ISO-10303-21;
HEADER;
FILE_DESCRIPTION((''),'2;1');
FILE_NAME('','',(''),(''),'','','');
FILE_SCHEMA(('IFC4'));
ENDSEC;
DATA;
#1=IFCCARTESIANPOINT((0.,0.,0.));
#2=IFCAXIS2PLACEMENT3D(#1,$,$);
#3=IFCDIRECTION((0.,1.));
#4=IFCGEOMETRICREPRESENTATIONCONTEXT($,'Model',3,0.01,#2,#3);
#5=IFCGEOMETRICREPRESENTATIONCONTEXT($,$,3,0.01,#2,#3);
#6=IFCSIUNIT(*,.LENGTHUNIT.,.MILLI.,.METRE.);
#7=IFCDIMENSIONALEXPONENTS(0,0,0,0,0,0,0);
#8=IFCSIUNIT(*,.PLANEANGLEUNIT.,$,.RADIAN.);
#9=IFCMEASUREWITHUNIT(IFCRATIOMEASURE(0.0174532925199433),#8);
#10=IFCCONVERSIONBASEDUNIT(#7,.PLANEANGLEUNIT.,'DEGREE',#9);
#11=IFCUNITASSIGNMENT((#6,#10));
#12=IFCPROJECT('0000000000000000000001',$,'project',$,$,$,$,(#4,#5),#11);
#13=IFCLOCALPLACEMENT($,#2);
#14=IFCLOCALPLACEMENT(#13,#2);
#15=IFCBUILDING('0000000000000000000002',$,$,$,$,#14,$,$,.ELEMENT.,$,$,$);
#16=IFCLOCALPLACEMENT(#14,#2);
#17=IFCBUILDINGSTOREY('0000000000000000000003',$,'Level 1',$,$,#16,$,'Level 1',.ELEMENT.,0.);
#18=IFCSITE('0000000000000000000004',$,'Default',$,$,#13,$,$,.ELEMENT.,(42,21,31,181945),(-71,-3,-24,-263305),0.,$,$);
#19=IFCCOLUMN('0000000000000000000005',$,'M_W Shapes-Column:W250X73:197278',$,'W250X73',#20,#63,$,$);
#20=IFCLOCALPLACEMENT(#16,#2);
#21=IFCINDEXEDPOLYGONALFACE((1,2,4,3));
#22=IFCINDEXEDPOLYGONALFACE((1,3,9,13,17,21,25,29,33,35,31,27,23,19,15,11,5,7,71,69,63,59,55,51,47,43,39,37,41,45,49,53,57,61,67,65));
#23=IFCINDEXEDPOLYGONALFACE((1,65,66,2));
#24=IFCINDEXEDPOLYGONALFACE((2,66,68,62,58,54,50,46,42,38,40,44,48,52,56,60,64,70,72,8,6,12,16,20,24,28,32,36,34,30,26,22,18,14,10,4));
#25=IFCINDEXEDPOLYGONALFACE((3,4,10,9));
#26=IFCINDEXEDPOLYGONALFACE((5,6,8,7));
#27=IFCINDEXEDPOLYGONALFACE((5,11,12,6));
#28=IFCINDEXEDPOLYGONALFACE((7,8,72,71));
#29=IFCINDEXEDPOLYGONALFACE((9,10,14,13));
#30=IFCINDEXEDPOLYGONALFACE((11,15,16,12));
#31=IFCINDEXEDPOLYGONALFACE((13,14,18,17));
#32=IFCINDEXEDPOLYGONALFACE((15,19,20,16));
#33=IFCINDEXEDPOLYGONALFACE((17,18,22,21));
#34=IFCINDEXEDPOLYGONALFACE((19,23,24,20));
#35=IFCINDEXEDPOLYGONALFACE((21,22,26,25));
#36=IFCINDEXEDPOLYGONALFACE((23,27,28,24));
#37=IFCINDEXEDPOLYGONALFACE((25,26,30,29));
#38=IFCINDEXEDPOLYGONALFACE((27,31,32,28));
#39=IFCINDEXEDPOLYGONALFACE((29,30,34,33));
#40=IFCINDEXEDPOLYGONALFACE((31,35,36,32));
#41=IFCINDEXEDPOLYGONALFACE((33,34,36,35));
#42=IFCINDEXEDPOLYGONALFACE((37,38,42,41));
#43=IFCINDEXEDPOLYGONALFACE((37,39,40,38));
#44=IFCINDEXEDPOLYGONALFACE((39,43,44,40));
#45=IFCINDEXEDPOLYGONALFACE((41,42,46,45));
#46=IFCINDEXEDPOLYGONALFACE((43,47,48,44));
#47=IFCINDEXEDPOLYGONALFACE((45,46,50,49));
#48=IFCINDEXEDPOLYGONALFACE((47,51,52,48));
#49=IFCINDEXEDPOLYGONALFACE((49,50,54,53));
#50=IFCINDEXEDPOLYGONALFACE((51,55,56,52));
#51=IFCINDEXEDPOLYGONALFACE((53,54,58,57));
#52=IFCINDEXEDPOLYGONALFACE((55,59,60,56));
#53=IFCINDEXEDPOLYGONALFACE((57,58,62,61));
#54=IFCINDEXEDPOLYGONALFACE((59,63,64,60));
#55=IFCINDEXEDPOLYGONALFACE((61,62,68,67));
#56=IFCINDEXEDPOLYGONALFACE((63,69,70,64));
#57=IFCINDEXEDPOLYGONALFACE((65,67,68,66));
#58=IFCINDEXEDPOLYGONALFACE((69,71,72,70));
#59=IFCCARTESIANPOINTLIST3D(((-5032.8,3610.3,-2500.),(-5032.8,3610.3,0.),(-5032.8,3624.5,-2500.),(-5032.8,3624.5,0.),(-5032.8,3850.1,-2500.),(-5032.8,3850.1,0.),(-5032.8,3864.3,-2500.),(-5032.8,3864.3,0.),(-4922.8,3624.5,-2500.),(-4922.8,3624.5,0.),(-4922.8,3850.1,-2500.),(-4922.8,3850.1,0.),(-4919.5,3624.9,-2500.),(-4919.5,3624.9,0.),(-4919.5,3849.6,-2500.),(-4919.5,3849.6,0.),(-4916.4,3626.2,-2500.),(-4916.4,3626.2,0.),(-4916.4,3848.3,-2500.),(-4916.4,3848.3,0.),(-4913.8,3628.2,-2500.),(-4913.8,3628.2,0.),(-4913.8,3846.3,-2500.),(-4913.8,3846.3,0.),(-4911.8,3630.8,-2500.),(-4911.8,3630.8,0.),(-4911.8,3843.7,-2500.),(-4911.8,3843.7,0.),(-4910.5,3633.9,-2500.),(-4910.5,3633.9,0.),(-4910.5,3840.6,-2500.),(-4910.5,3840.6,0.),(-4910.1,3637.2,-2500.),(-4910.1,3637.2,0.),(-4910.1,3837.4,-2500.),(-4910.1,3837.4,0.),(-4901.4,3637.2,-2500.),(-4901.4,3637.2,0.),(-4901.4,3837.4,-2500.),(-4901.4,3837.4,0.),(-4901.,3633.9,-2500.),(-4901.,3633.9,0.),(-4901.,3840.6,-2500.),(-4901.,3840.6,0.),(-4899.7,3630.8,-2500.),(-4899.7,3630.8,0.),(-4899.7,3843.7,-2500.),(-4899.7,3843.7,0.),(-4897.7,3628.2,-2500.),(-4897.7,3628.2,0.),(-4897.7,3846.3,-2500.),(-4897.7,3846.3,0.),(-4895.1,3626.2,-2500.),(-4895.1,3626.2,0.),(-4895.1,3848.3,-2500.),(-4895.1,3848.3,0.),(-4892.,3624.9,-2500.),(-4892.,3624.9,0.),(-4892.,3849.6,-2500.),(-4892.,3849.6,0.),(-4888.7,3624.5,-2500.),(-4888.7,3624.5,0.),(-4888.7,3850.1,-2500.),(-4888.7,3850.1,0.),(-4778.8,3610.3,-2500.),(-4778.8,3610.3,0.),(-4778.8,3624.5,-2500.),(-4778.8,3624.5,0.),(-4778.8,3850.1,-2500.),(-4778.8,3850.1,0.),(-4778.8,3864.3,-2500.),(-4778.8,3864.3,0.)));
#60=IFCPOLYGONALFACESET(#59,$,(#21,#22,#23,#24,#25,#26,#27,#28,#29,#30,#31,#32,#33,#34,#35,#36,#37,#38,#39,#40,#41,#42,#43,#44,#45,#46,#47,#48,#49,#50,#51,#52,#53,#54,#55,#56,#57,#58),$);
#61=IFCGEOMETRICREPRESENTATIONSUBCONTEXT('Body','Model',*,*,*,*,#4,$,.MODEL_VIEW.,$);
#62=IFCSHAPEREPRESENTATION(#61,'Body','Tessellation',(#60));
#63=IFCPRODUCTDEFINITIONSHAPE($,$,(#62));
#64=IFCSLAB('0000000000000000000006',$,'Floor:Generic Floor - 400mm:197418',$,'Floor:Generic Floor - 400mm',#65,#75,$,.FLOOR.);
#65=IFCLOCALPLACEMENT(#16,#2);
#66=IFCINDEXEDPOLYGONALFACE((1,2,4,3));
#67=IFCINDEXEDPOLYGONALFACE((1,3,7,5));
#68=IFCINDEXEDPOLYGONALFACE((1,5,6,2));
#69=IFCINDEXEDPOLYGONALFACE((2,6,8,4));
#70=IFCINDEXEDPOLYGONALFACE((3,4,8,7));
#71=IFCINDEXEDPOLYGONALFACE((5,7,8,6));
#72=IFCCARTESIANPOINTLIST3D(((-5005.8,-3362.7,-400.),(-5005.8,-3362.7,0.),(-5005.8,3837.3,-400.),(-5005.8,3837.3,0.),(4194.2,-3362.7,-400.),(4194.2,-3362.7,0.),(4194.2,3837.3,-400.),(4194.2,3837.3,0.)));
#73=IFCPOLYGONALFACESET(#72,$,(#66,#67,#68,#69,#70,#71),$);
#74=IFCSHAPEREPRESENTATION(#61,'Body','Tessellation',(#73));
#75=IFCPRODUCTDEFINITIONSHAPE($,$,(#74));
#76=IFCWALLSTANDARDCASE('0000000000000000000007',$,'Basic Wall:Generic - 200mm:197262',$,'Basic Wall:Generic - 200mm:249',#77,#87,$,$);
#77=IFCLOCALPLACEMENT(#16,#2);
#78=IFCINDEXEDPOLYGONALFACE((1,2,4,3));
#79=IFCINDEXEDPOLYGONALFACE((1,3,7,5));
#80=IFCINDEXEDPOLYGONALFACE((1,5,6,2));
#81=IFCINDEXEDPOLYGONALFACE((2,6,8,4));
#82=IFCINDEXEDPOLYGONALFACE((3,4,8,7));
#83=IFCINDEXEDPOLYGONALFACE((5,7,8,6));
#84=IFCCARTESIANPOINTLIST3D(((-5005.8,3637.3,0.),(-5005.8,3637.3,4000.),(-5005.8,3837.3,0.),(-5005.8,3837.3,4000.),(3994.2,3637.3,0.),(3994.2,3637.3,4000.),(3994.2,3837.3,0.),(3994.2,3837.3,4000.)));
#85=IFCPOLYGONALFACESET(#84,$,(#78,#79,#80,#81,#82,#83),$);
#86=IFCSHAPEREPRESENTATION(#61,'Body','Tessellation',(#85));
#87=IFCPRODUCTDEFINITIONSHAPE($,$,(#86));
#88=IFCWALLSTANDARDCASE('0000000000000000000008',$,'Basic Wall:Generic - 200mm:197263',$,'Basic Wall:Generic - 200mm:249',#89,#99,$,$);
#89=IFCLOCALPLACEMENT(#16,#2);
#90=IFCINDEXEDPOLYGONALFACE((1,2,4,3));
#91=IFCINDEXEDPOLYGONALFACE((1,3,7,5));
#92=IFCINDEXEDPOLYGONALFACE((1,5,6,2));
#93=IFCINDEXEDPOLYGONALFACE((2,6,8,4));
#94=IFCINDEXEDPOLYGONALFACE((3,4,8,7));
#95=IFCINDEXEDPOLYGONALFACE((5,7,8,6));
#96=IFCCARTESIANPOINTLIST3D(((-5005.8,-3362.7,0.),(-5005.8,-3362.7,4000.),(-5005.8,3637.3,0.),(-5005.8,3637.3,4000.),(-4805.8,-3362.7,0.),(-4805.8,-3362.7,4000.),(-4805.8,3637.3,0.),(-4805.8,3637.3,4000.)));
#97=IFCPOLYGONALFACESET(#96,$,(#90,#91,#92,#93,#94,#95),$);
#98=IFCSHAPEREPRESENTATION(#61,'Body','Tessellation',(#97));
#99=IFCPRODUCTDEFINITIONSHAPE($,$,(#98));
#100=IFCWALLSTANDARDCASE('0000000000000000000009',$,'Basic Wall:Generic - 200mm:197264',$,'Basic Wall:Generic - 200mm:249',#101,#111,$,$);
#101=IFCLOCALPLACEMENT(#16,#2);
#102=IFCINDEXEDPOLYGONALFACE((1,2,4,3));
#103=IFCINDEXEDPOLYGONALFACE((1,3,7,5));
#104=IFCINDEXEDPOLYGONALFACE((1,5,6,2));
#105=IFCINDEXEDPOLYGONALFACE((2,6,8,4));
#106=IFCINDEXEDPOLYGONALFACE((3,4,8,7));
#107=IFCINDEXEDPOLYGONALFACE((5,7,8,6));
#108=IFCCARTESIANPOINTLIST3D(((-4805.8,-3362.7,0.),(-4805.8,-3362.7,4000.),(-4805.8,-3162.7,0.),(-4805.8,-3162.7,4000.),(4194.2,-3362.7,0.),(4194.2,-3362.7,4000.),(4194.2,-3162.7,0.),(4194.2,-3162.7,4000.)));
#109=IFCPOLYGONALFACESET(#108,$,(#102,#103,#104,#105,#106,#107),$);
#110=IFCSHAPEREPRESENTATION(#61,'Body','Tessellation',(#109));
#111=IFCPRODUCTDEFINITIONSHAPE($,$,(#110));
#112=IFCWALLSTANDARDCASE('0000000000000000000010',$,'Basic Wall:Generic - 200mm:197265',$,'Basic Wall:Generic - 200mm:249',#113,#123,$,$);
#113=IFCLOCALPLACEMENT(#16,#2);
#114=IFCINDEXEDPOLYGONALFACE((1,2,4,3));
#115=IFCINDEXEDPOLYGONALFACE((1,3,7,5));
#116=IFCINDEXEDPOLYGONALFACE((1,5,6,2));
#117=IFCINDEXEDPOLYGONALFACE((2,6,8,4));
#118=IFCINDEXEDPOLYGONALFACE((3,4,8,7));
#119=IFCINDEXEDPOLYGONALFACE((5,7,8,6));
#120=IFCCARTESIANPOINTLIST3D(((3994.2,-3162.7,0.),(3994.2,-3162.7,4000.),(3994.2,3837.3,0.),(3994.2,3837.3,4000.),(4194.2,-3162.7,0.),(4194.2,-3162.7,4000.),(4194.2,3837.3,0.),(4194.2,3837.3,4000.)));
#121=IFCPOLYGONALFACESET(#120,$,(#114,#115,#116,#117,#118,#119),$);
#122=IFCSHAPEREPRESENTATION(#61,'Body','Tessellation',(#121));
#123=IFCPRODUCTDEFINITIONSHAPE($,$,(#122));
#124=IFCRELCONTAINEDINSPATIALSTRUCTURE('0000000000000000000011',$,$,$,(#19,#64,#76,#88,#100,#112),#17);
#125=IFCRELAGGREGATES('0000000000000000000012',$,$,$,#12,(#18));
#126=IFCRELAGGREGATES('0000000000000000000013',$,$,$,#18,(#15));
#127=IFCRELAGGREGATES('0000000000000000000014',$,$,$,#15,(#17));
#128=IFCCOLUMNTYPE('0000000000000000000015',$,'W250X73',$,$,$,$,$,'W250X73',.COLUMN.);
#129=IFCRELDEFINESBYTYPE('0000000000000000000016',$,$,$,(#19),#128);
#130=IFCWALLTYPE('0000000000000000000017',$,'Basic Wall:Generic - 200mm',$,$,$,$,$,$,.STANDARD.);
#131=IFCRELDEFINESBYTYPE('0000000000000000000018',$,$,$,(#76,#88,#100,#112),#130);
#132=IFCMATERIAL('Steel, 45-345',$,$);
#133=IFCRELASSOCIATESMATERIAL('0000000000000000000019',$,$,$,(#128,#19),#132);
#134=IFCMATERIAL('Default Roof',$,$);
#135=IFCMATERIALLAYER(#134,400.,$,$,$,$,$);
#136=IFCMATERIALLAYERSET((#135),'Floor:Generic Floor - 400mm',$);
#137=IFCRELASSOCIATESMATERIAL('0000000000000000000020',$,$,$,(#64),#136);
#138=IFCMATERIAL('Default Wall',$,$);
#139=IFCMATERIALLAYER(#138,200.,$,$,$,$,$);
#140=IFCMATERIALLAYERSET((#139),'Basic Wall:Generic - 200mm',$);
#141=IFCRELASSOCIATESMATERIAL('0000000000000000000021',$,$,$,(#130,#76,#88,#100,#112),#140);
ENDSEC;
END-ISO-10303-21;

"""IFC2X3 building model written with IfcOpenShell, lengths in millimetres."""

from ifc_helpers import new_model, entity, si_unit, converted_unit, direction, frame, frame_2d, origin, origin_2d_with_axis, place, context, subcontext, project, spatial, rectangle, i_section, extrude, source, transform, mapped, material, layer, layer_set, layer_usage, type_object, type_shapes, element, save


model = new_model("IFC2X3")

# Units and contexts
model_context = context("Model", 3, precision=0.01, world=origin(), true_north=direction((0.0, 1.0)))
context_of_model = context(None, 3, precision=0.01, world=origin(), true_north=direction((0.0, 1.0)))
body_context = subcontext(model_context, "Body", "Model", "MODEL_VIEW")
ifc_project = project(units=[si_unit("LENGTHUNIT", "METRE", prefix="MILLI"), converted_unit("PLANEANGLEUNIT", "DEGREE", entity("IfcRatioMeasure", 0.0174532925199433), si_unit("PLANEANGLEUNIT", "RADIAN"), dimensions=[0, 0, 0, 0, 0, 0, 0])], contexts=[model_context, context_of_model])

# Site, building, storey
site_placement = place(None, origin())
site = spatial("IfcSite", under=ifc_project, at=site_placement, Name="Default", CompositionType="ELEMENT", RefLatitude=(42, 21, 31, 181945), RefLongitude=(-71, -3, -24, -263305), RefElevation=0.0)
building_placement = place(site_placement, origin())
building = spatial("IfcBuilding", under=site, at=building_placement, CompositionType="ELEMENT")
storey_placement = place(building_placement, origin())
storey = spatial("IfcBuildingStorey", under=building, at=storey_placement, Name="Level 1", LongName="Level 1", CompositionType="ELEMENT", Elevation=0.0)

# Column
ifc_material_1 = material(Name="Steel, 45-345")
column_type = type_object("IfcColumnType", Name="W250X73", ElementType="W250X73", PredefinedType="COLUMN", material=ifc_material_1)
shared_shape = source(origin(), body_context, "Body", "SweptSolid", [
    extrude(i_section(OverallWidth=254.0, OverallDepth=254.0, WebThickness=8.6, FlangeThickness=14.2, FilletRadius=12.7, at=frame_2d((0.0, 0.0), x_axis=(1.0, 0.0))), frame((0.0, 0.0, -2500.0), z_axis=(0.0, 0.0, 1.0), x_axis=(-1.0, 0.0, 0.0)), (0.0, 0.0, 1.0), 2500.0),
])
type_shapes(column_type, [shared_shape])
column_placement = place(storey_placement, frame((-4905.8, 3737.3, 0.0)))
element("IfcColumn", 1, at=column_placement, inside=storey, type_object=column_type, material=ifc_material_1, Name="M_W Shapes-Column:W250X73:197278", ObjectType="W250X73", context=body_context, shape_type="MappedRepresentation", body=[
    mapped(shared_shape, transform((0.0, 0.0, 0.0), scale=1.0)),
])

# Slab
ifc_material_2 = material(Name="Default Roof")
ifc_layer_1 = layer(ifc_material_2, 400.0)
ifc_layer_set_1 = layer_set([ifc_layer_1], Name="Floor:Generic Floor - 400mm")
ifc_layer_usage_1 = layer_usage(ifc_layer_set_1, "AXIS3", "POSITIVE", 0.0)
slab_placement = place(storey_placement, origin())
element("IfcSlab", 2, at=slab_placement, inside=storey, material=ifc_layer_usage_1, Name="Floor:Generic Floor - 400mm:197418", ObjectType="Floor:Generic Floor - 400mm", PredefinedType="FLOOR", context=body_context, shape_type="SweptSolid", body=[
    extrude(rectangle(XDim=7200.0, YDim=9200.0, at=origin_2d_with_axis()), frame((-405.8, 237.3, 0.0), z_axis=(0.0, 0.0, -1.0), x_axis=(0.0, 1.0, 0.0)), (0.0, 0.0, 1.0), 400.0),
])

# Walls
ifc_material_3 = material(Name="Default Wall")
ifc_layer_2 = layer(ifc_material_3, 200.0)
ifc_layer_set_2 = layer_set([ifc_layer_2], Name="Basic Wall:Generic - 200mm")
ifc_layer_usage_2 = layer_usage(ifc_layer_set_2, "AXIS2", "NEGATIVE", 100.0)
wall_type = type_object("IfcWallType", Name="Basic Wall:Generic - 200mm", PredefinedType="STANDARD", material=ifc_layer_set_2)
wall_1_placement = place(storey_placement, frame((-5005.8, 3737.3, 0.0)))
element("IfcWallStandardCase", 3, at=wall_1_placement, inside=storey, type_object=wall_type, material=ifc_layer_usage_2, Name="Basic Wall:Generic - 200mm:197262", ObjectType="Basic Wall:Generic - 200mm:249", context=body_context, shape_type="SweptSolid", body=[
    extrude(rectangle(XDim=9000.0, YDim=200.0, at=frame_2d((4500.0, 0.0), x_axis=(-1.0, 0.0))), origin(), (0.0, 0.0, 1.0), 4000.0),
])
ifc_layer_usage_3 = layer_usage(ifc_layer_set_2, "AXIS2", "NEGATIVE", 100.0)
wall_2_placement = place(storey_placement, frame((-4905.8, -3362.7, 0.0), z_axis=(0.0, 0.0, 1.0), x_axis=(0.0, 1.0, 0.0)))
element("IfcWallStandardCase", 4, at=wall_2_placement, inside=storey, type_object=wall_type, material=ifc_layer_usage_3, Name="Basic Wall:Generic - 200mm:197263", ObjectType="Basic Wall:Generic - 200mm:249", context=body_context, shape_type="SweptSolid", body=[
    extrude(rectangle(XDim=7000.0, YDim=200.0, at=frame_2d((3500.0, 0.0), x_axis=(-1.0, 0.0))), origin(), (0.0, 0.0, 1.0), 4000.0),
])
ifc_layer_usage_4 = layer_usage(ifc_layer_set_2, "AXIS2", "NEGATIVE", 100.0)
wall_3_placement = place(storey_placement, frame((4194.2, -3262.7, 0.0), z_axis=(0.0, 0.0, 1.0), x_axis=(-1.0, 0.0, 0.0)))
element("IfcWallStandardCase", 5, at=wall_3_placement, inside=storey, type_object=wall_type, material=ifc_layer_usage_4, Name="Basic Wall:Generic - 200mm:197264", ObjectType="Basic Wall:Generic - 200mm:249", context=body_context, shape_type="SweptSolid", body=[
    extrude(rectangle(XDim=9000.0, YDim=200.0, at=frame_2d((4500.0, 0.0), x_axis=(-1.0, 0.0))), origin(), (0.0, 0.0, 1.0), 4000.0),
])
ifc_layer_usage_5 = layer_usage(ifc_layer_set_2, "AXIS2", "NEGATIVE", 100.0)
wall_4_placement = place(storey_placement, frame((4094.2, 3837.3, 0.0), z_axis=(0.0, 0.0, 1.0), x_axis=(0.0, -1.0, 0.0)))
element("IfcWallStandardCase", 6, at=wall_4_placement, inside=storey, type_object=wall_type, material=ifc_layer_usage_5, Name="Basic Wall:Generic - 200mm:197265", ObjectType="Basic Wall:Generic - 200mm:249", context=body_context, shape_type="SweptSolid", body=[
    extrude(rectangle(XDim=7000.0, YDim=200.0, at=frame_2d((3500.0, 0.0), x_axis=(-1.0, 0.0))), origin(), (0.0, 0.0, 1.0), 4000.0),
])

save(model, "model.ifc")
